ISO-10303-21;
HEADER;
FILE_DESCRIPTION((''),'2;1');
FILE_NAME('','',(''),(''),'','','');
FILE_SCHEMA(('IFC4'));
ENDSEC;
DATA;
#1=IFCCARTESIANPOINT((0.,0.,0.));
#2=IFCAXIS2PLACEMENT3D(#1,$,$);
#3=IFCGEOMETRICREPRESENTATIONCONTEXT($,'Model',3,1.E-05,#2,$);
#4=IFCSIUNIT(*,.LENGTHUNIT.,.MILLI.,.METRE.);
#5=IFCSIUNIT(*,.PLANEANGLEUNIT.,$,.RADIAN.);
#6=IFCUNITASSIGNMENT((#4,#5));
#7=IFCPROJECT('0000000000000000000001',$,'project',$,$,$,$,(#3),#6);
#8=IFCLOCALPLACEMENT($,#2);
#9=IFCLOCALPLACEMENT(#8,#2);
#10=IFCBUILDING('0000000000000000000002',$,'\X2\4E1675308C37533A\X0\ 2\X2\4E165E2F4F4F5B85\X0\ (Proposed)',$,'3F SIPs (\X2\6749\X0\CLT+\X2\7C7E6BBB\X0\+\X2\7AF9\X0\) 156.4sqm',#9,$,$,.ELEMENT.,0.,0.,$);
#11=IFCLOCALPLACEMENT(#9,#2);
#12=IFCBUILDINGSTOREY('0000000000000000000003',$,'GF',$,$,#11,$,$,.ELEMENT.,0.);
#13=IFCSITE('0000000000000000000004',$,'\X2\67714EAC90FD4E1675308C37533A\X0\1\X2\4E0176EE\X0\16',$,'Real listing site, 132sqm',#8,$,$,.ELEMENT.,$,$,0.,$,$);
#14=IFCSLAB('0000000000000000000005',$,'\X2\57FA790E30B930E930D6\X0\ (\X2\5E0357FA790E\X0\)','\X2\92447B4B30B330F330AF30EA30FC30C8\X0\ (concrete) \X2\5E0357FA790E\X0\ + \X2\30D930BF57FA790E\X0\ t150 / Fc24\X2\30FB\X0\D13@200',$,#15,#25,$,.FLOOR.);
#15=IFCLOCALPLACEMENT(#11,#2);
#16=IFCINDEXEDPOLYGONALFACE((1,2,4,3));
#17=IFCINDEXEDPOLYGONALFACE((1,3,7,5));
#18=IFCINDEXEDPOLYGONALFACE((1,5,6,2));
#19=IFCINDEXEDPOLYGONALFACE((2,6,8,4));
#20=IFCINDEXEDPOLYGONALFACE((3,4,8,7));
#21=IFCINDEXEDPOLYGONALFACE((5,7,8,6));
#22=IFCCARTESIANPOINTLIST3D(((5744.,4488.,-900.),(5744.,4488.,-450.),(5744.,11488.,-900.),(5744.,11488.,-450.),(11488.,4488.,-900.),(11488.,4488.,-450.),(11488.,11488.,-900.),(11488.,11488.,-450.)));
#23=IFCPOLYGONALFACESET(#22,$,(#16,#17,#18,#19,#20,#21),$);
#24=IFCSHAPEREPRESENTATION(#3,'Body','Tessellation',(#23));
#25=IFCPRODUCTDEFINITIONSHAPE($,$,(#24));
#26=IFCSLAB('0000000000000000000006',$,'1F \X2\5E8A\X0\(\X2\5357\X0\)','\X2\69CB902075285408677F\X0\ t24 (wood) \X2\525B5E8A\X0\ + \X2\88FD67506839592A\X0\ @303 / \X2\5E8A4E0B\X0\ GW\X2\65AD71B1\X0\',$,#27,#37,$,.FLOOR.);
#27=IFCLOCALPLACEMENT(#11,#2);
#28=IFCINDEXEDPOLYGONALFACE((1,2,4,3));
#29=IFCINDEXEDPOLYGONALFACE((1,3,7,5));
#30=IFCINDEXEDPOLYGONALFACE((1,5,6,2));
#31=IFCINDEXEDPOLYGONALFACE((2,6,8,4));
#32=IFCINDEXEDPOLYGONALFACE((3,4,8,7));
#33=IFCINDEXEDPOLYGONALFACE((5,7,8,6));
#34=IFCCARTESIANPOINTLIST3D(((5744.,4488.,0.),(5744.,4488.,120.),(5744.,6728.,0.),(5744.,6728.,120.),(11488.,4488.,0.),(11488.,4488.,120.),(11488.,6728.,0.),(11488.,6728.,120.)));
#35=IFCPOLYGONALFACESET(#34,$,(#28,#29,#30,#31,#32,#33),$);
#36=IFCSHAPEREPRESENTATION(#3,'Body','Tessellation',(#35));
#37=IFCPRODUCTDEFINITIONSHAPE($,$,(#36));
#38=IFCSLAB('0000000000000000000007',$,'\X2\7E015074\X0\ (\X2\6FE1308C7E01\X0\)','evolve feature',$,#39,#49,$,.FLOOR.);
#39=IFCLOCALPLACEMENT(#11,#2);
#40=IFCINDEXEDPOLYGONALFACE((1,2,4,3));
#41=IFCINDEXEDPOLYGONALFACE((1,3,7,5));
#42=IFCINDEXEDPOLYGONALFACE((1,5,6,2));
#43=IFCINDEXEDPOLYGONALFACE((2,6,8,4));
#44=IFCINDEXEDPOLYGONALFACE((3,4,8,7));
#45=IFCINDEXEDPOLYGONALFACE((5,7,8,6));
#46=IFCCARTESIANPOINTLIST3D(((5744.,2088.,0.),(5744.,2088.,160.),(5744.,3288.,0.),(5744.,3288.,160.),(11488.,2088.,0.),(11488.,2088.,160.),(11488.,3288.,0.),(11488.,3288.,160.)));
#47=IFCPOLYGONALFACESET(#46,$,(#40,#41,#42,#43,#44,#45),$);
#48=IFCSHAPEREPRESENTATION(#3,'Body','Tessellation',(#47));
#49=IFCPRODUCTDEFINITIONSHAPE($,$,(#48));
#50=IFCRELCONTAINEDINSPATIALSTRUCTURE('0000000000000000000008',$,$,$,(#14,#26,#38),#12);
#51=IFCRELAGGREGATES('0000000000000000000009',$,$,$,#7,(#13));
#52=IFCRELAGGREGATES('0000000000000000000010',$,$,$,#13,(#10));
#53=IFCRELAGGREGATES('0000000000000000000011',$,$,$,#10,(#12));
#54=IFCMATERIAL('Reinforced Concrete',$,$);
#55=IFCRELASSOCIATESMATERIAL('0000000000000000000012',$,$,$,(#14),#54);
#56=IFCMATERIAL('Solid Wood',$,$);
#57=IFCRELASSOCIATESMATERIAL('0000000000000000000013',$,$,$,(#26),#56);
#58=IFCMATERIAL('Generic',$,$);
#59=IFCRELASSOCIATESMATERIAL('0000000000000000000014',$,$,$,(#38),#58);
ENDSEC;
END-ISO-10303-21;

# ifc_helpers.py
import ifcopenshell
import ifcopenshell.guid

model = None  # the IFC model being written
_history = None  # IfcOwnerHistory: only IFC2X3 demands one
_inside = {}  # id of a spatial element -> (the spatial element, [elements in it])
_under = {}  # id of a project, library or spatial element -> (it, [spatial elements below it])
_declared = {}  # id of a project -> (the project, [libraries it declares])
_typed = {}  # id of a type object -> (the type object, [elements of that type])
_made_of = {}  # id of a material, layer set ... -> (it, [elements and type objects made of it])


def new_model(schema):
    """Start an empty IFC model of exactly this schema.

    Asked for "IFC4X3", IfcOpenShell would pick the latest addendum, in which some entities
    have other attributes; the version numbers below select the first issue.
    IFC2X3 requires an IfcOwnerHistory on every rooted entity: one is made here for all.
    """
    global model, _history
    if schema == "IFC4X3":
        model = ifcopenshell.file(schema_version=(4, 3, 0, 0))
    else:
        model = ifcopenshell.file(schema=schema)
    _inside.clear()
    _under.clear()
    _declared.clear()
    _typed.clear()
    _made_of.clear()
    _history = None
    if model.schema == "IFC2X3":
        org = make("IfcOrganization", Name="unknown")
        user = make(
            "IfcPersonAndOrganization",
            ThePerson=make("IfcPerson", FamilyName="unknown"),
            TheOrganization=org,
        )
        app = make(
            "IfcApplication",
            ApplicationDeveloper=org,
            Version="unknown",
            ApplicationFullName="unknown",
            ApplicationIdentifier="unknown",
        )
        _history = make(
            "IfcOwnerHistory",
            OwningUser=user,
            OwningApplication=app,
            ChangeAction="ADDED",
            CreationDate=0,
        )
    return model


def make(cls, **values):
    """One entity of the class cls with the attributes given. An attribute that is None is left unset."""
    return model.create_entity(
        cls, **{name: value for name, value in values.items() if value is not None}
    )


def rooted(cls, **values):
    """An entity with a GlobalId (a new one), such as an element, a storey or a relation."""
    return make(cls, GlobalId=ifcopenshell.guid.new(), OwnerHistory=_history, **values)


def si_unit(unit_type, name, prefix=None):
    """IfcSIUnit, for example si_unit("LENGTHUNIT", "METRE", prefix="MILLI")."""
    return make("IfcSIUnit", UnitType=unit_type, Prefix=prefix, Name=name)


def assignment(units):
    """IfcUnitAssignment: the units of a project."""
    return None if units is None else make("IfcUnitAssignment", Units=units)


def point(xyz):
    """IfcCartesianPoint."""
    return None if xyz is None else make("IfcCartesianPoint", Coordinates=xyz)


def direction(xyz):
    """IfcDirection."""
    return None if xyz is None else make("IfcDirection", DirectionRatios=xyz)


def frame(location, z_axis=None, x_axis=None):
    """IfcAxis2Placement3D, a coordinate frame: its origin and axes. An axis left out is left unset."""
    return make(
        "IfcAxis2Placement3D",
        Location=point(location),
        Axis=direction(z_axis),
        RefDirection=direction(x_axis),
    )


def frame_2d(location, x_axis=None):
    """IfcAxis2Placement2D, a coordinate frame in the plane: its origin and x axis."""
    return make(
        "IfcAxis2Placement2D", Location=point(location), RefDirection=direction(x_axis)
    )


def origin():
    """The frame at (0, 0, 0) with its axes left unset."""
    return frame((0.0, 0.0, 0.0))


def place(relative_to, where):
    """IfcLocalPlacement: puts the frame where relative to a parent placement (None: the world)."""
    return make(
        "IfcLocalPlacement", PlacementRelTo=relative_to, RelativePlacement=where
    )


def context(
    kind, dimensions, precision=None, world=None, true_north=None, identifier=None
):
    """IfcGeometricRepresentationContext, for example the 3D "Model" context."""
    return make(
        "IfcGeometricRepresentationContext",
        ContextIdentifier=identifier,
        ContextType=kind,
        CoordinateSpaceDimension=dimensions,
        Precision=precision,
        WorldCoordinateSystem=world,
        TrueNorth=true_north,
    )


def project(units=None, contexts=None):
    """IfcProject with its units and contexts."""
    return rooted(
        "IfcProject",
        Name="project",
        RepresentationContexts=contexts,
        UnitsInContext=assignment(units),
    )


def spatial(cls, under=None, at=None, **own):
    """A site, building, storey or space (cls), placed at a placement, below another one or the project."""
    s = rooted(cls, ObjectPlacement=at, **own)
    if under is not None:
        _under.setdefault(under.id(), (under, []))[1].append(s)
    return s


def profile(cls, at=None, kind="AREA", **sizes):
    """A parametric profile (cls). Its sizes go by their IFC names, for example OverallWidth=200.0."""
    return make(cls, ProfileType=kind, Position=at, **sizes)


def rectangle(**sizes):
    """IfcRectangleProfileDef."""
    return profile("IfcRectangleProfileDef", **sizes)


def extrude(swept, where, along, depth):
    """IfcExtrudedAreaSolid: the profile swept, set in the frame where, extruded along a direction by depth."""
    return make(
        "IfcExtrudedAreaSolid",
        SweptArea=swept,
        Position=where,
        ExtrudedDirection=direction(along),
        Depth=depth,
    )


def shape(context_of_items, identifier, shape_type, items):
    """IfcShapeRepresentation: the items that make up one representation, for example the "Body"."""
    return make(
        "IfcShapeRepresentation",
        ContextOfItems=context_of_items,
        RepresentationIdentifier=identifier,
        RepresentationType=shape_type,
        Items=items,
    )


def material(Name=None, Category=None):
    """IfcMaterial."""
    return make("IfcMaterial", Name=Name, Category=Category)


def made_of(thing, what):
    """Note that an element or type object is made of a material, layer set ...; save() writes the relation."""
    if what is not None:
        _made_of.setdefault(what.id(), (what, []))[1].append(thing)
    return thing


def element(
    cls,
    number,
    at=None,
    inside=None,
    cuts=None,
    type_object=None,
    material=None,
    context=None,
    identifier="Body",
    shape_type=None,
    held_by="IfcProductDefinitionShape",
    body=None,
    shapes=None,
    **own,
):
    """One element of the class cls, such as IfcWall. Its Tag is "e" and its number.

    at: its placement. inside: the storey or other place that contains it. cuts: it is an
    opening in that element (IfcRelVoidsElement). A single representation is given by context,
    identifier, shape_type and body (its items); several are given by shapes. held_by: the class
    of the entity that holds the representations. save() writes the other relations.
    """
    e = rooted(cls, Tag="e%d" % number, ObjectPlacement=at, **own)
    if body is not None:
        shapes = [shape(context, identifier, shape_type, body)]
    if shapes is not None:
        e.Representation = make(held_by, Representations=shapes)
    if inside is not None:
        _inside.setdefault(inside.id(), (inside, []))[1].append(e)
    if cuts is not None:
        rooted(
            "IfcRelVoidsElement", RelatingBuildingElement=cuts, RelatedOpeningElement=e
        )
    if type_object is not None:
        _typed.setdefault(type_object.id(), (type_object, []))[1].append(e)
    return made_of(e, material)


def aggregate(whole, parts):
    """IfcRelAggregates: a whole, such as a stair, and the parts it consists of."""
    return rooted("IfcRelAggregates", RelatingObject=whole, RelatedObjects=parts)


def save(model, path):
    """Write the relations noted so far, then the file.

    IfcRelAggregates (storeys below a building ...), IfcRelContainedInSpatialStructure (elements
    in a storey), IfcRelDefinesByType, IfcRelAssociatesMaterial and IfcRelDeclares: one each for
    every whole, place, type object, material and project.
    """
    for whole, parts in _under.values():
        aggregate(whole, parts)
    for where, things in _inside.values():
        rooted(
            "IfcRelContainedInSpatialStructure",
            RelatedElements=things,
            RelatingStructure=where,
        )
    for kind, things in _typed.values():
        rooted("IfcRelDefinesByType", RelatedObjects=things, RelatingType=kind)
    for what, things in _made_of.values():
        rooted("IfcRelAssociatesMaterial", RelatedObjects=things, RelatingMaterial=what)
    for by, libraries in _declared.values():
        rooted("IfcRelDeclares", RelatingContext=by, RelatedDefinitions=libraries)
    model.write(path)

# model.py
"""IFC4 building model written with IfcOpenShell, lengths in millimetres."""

from ifc_helpers import new_model, si_unit, frame, frame_2d, origin, place, context, project, spatial, rectangle, extrude, material, element, save


model = new_model("IFC4")

# Units and contexts
model_context = context("Model", 3, precision=1e-05, world=origin())
ifc_project = project(units=[si_unit("LENGTHUNIT", "METRE", prefix="MILLI"), si_unit("PLANEANGLEUNIT", "RADIAN")], contexts=[model_context])

# Site, building, storey
site_placement = place(None, origin())
site = spatial("IfcSite", under=ifc_project, at=site_placement, Name="東京都世田谷区1丁目16", ObjectType="Real listing site, 132sqm", CompositionType="ELEMENT", RefElevation=0.0)
building_placement = place(site_placement, origin())
building = spatial("IfcBuilding", under=site, at=building_placement, Name="世田谷区 2世帯住宅 (Proposed)", ObjectType="3F SIPs (杉CLT+籾殻+竹) 156.4sqm", CompositionType="ELEMENT", ElevationOfRefHeight=0.0, ElevationOfTerrain=0.0)
storey_placement = place(building_placement, origin())
storey = spatial("IfcBuildingStorey", under=building, at=storey_placement, Name="GF", CompositionType="ELEMENT", Elevation=0.0)

# Slabs
ifc_material_1 = material(Name="Reinforced Concrete")
slab_1_placement = place(storey_placement, frame((2872.0, 2244.0, -450.0)))
element("IfcSlab", 1, at=slab_1_placement, inside=storey, material=ifc_material_1, Name="基礎スラブ (布基礎)", Description="鉄筋コンクリート (concrete) 布基礎 + ベタ基礎 t150 / Fc24・D13@200", PredefinedType="FLOOR", context=model_context, shape_type="SweptSolid", body=[
    extrude(rectangle(XDim=5744.0, YDim=7000.0, at=frame_2d((2872.0, 3500.0))), frame((2872.0, 2244.0, -450.0)), (0.0, 0.0, 1.0), 450.0),
])
ifc_material_2 = material(Name="Solid Wood")
slab_2_placement = place(storey_placement, frame((2872.0, 2244.0, 0.0)))
element("IfcSlab", 2, at=slab_2_placement, inside=storey, material=ifc_material_2, Name="1F 床(南)", Description="構造用合板 t24 (wood) 剛床 + 製材根太 @303 / 床下 GW断熱", PredefinedType="FLOOR", context=model_context, shape_type="SweptSolid", body=[
    extrude(rectangle(XDim=5744.0, YDim=2240.0, at=frame_2d((2872.0, 1120.0))), frame((2872.0, 2244.0, 0.0)), (0.0, 0.0, 1.0), 120.0),
])
ifc_material_3 = material(Name="Generic")
slab_3_placement = place(storey_placement, frame((2872.0, 1044.0, 0.0)))
element("IfcSlab", 3, at=slab_3_placement, inside=storey, material=ifc_material_3, Name="縁側 (濡れ縁)", Description="evolve feature", PredefinedType="FLOOR", context=model_context, shape_type="SweptSolid", body=[
    extrude(rectangle(XDim=5744.0, YDim=1200.0, at=frame_2d((2872.0, 600.0))), frame((2872.0, 1044.0, 0.0)), (0.0, 0.0, 1.0), 160.0),
])

save(model, "model.ifc")
